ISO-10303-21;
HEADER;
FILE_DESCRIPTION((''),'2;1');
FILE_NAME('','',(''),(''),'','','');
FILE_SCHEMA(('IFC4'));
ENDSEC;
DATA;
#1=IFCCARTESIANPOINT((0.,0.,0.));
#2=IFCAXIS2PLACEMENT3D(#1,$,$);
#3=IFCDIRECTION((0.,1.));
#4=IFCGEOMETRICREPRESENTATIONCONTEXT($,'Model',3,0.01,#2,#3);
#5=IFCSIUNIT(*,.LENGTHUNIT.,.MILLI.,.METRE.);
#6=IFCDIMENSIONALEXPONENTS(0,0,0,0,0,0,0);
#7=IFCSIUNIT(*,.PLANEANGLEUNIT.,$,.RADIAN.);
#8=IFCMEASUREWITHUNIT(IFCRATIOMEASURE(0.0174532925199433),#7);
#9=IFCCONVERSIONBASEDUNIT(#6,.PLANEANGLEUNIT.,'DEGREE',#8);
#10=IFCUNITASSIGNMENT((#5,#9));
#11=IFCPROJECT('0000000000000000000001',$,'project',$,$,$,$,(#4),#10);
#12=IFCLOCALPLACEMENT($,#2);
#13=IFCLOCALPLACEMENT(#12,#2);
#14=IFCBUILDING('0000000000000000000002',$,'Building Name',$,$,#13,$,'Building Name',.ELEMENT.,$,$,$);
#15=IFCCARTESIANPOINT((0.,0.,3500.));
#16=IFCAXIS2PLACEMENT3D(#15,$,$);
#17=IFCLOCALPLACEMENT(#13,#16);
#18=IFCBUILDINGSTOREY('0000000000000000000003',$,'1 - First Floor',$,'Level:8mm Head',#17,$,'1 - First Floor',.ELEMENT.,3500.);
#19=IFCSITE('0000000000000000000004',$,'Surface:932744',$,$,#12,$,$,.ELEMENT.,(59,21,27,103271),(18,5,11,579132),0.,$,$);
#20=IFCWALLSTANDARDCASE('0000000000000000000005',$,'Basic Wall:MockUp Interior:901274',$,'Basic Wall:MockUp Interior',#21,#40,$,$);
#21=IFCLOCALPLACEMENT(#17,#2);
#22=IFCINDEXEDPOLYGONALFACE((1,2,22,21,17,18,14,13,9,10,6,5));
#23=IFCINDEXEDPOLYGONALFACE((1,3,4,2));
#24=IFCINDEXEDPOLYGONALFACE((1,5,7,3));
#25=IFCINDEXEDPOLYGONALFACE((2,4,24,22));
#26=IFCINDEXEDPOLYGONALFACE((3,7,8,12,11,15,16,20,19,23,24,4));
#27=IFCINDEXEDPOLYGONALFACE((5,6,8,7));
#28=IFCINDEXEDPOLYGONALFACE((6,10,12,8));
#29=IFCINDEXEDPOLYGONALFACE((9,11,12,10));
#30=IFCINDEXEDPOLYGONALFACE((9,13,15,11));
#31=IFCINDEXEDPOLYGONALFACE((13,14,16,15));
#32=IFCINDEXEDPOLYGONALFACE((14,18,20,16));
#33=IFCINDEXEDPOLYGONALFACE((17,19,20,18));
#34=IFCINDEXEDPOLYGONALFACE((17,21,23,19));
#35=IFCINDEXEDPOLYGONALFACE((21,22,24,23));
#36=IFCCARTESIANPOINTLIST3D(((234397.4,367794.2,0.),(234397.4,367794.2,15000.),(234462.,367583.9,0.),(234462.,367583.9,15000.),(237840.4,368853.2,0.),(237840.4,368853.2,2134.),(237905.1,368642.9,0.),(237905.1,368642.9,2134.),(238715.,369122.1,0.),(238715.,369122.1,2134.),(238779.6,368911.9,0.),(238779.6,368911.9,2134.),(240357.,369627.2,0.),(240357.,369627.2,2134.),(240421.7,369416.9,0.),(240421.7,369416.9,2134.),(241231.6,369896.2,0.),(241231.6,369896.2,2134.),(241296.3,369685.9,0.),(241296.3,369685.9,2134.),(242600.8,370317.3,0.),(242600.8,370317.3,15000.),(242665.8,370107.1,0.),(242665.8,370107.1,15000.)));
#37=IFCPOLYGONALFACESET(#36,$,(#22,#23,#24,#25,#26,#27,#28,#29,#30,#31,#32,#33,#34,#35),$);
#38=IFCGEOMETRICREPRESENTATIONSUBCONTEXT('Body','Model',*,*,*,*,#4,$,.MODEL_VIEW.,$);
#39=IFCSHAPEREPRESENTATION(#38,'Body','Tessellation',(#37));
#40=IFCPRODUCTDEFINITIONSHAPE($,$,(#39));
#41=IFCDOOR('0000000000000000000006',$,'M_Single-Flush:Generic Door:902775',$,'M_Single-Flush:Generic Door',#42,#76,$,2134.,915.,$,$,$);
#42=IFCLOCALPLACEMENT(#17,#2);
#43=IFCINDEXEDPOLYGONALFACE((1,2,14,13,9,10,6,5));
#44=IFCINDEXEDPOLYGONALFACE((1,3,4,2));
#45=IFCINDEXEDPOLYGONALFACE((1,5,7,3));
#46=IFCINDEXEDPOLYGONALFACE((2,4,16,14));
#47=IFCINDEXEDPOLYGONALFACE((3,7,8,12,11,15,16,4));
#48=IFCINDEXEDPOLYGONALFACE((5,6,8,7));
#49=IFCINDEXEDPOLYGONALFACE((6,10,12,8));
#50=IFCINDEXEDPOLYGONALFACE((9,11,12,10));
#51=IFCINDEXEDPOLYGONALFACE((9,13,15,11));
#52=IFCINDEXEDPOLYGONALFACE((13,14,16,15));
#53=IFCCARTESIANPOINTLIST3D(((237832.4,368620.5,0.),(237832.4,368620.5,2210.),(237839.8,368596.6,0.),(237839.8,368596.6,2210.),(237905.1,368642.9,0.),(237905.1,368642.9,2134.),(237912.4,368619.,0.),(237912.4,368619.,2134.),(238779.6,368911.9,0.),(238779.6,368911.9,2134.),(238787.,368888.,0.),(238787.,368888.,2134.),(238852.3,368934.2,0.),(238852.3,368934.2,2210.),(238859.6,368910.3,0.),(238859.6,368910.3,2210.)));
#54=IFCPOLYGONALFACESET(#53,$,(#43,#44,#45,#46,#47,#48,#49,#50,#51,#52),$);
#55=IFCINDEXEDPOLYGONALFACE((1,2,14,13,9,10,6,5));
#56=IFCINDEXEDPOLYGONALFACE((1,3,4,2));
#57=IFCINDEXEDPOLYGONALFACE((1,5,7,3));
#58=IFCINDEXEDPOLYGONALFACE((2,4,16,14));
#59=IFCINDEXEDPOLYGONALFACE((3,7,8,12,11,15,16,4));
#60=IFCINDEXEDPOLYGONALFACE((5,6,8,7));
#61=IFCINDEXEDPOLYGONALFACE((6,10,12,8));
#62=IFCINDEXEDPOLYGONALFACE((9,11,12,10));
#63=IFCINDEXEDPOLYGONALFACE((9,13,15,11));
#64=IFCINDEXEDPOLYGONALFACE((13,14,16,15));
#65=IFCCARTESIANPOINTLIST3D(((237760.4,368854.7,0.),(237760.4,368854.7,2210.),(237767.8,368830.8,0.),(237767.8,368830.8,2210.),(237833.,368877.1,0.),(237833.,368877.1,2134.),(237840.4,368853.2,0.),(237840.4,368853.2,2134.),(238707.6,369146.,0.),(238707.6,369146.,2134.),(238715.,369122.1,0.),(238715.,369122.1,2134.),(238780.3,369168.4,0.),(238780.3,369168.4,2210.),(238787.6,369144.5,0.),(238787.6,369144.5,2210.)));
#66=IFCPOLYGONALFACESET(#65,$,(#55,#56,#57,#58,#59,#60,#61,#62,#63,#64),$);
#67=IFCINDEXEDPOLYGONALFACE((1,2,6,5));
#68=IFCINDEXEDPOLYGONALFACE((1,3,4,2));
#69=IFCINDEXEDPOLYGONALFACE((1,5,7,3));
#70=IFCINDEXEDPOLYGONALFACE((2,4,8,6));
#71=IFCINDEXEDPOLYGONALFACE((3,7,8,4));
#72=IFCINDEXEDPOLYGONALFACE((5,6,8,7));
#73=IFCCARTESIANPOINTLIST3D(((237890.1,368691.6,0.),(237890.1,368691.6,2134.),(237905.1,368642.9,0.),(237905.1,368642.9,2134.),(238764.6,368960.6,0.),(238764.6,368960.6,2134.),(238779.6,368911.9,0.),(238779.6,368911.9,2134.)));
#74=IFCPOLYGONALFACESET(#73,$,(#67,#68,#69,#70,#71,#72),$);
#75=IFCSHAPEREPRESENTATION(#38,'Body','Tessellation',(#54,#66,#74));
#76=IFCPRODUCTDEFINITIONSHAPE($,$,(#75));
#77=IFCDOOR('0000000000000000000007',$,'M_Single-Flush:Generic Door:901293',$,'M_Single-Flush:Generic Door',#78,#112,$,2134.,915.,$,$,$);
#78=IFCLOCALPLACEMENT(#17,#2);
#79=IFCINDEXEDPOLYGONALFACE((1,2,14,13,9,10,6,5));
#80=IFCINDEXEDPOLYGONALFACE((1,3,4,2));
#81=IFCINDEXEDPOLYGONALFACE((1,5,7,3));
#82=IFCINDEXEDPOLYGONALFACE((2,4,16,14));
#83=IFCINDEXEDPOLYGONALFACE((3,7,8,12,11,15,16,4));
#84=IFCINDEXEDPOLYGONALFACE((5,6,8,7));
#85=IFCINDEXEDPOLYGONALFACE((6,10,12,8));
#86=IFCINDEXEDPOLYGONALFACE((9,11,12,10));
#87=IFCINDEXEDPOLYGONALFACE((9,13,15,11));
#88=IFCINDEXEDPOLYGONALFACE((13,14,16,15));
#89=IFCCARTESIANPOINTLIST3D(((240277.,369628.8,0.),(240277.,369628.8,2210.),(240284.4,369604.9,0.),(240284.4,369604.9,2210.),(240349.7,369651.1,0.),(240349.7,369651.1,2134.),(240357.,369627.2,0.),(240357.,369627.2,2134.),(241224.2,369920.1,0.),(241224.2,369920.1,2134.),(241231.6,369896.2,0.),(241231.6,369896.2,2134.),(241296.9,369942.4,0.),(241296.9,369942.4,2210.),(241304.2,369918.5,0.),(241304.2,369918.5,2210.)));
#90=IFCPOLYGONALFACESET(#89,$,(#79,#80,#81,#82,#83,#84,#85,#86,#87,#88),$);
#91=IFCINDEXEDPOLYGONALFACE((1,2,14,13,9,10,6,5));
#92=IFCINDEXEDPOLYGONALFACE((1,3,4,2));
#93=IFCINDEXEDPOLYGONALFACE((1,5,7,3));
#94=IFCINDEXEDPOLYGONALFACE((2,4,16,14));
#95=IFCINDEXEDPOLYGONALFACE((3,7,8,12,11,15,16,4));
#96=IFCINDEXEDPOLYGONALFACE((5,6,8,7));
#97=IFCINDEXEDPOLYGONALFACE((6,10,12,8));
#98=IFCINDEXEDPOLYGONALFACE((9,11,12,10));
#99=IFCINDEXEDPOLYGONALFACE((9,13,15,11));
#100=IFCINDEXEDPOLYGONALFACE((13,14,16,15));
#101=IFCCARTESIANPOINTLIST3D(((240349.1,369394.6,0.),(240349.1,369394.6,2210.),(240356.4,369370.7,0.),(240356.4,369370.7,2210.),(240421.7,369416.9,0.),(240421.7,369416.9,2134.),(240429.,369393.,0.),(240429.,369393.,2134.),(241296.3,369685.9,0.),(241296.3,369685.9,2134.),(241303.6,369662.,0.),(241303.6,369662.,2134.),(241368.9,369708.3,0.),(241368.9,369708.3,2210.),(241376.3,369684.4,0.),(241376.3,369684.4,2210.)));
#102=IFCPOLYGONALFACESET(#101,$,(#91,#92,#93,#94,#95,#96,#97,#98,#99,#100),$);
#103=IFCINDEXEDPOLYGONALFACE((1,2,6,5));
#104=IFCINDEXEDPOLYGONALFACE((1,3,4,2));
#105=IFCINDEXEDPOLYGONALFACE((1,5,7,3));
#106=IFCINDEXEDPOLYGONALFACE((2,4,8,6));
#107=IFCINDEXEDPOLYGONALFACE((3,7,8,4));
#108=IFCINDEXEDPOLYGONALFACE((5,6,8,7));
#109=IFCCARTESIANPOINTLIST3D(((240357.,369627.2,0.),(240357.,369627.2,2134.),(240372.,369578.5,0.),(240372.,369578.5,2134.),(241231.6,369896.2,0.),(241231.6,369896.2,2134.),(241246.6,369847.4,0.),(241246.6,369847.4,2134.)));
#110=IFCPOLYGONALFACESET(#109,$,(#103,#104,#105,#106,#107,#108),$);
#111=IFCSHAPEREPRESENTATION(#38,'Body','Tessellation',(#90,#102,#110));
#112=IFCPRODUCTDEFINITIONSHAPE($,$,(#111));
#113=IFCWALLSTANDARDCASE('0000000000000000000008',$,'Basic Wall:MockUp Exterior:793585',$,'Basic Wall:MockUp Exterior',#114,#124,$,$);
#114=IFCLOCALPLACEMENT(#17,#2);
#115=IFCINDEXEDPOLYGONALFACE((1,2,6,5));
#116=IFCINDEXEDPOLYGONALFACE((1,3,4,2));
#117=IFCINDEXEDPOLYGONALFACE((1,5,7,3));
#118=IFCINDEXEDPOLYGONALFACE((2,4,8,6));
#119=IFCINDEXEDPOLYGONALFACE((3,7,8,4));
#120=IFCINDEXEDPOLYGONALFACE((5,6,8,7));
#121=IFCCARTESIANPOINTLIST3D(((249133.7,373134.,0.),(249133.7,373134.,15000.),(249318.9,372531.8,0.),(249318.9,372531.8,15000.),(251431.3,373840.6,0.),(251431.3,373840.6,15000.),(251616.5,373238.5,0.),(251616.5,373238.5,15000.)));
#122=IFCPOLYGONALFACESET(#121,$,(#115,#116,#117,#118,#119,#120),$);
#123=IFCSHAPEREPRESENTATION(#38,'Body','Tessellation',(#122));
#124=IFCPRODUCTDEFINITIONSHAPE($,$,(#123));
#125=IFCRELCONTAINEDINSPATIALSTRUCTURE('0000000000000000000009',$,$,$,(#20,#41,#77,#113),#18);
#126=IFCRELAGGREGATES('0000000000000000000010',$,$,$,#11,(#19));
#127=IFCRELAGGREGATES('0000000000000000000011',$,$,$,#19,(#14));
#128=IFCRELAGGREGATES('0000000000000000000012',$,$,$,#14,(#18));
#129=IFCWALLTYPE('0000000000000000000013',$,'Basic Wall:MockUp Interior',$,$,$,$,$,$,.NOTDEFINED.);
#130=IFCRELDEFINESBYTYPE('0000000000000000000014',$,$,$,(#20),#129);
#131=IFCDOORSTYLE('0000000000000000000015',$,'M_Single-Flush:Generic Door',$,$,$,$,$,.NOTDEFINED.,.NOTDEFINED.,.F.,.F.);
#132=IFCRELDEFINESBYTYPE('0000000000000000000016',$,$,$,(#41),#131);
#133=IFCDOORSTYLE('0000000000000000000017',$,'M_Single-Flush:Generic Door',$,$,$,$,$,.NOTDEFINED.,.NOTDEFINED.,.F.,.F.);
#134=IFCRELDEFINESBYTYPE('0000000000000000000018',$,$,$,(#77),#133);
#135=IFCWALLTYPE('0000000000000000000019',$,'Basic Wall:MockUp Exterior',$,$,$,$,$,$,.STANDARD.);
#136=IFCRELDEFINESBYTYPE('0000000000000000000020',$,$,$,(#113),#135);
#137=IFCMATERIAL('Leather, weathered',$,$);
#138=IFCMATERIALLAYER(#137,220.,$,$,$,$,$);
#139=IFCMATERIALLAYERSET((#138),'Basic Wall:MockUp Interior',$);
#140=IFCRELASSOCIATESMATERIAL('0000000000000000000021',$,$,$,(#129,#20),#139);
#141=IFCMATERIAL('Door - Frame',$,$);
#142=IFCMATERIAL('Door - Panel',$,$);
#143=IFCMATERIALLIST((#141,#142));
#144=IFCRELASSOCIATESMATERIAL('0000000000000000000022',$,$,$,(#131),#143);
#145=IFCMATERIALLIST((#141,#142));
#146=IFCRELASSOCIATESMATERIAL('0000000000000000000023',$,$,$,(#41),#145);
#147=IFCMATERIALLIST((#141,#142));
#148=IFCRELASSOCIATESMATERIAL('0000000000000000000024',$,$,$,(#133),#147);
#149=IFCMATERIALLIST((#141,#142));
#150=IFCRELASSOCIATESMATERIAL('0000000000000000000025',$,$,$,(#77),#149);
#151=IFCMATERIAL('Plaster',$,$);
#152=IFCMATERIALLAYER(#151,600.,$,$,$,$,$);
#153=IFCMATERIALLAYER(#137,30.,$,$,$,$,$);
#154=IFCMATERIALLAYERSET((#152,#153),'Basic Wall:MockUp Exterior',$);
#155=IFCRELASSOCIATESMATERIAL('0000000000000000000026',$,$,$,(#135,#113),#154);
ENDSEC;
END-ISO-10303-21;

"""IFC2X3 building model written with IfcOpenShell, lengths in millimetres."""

from ifc_helpers import new_model, entity, si_unit, converted_unit, direction, frame, frame_2d, origin, place, context, subcontext, project, spatial, polyline, rectangle, outline, extrude, source, transform, mapped, material, material_list, layer, layer_set, layer_usage, type_object, type_shapes, element, fill, save


model = new_model("IFC2X3")

# Units and contexts
model_context = context("Model", 3, precision=0.01, world=origin(), true_north=direction((0.0, 1.0)))
body_context = subcontext(model_context, "Body", "Model", "MODEL_VIEW")
ifc_project = project(units=[si_unit("LENGTHUNIT", "METRE", prefix="MILLI"), converted_unit("PLANEANGLEUNIT", "DEGREE", entity("IfcRatioMeasure", 0.0174532925199433), si_unit("PLANEANGLEUNIT", "RADIAN"), dimensions=[0, 0, 0, 0, 0, 0, 0])], contexts=[model_context])

# Site, building, storey
site_placement = place(None, origin())
site = spatial("IfcSite", under=ifc_project, at=site_placement, Name="Surface:932744", CompositionType="ELEMENT", RefLatitude=(59, 21, 27, 103271), RefLongitude=(18, 5, 11, 579132), RefElevation=0.0)
building_placement = place(site_placement, origin())
building = spatial("IfcBuilding", under=site, at=building_placement, Name="Building Name", LongName="Building Name", CompositionType="ELEMENT")
storey_placement = place(building_placement, frame((0.0, 0.0, 3500.0)))
storey = spatial("IfcBuildingStorey", under=building, at=storey_placement, Name="1 - First Floor", ObjectType="Level:8mm Head", LongName="1 - First Floor", CompositionType="ELEMENT", Elevation=3500.0)

# Shared definitions
ifc_material_1 = material(Name="Leather, weathered")

# Shared definitions
ifc_material_2 = material(Name="Door - Frame")
ifc_material_3 = material(Name="Door - Panel")

# Shared definitions
ifc_layer_1 = layer(ifc_material_1, 220.0)
ifc_layer_set_1 = layer_set([ifc_layer_1], Name="Basic Wall:MockUp Interior")
wall_type_1 = type_object("IfcWallType", Name="Basic Wall:MockUp Interior", PredefinedType="NOTDEFINED", material=ifc_layer_set_1)
ifc_material_list_1 = material_list([ifc_material_2, ifc_material_3])
door_style_1 = type_object("IfcDoorStyle", Name="M_Single-Flush:Generic Door", ConstructionType="NOTDEFINED", OperationType="NOTDEFINED", ParameterTakesPrecedence=False, Sizeable=False, material=ifc_material_list_1)
shared_shape_1 = source(origin(), body_context, "Body", "SweptSolid", [
    extrude(outline(polyline([(-533.5, -1124.0), (533.5, -1124.0), (533.5, 1086.0), (457.5, 1086.0), (457.5, -1048.0), (-457.5, -1048.0), (-457.5, 1086.0), (-533.5, 1086.0), (-533.5, -1124.0)])), frame((457.5, 245.0, 1086.0), z_axis=(0.0, -1.0, 0.0), x_axis=(-1.0, 0.0, 0.0)), (0.0, 0.0, 1.0), 25.0),
    extrude(outline(polyline([(-1124.0, -533.5), (1086.0, -533.5), (1086.0, -457.5), (-1048.0, -457.5), (-1048.0, 457.5), (1086.0, 457.5), (1086.0, 533.5), (-1124.0, 533.5), (-1124.0, -533.5)])), frame((457.5, 0.0, 1086.0), z_axis=(0.0, -1.0, 0.0), x_axis=(0.0, 0.0, -1.0)), (0.0, 0.0, 1.0), 25.0),
    extrude(rectangle(XDim=915.0, YDim=51.0, at=frame_2d((0.0, 0.0), x_axis=(1.0, 0.0))), frame((457.5, 194.5, 0.0)), (0.0, 0.0, 1.0), 2134.0),
])
type_shapes(door_style_1, [shared_shape_1])

# Wall, openings, doors
ifc_layer_usage_1 = layer_usage(ifc_layer_set_1, "AXIS2", "NEGATIVE", 110.0)
wall_1_placement = place(storey_placement, frame((242633.4, 370212.3, 0.0), z_axis=(0.0, 0.0, 1.0), x_axis=(-0.955811, -0.29398, 0.0)))
wall_1 = element("IfcWallStandardCase", 1, at=wall_1_placement, inside=storey, type_object=wall_type_1, material=ifc_layer_usage_1, Name="Basic Wall:MockUp Interior:901274", ObjectType="Basic Wall:MockUp Interior", context=body_context, shape_type="SweptSolid", body=[
    extrude(outline(polyline([(0.3, -110.0), (8583.0, -110.0), (8583.0, 110.0), (3825.8, 110.0), (3605.8, 110.0), (220.0, 110.0), (0.0, 110.0), (0.3, -110.0)])), origin(), (0.0, 0.0, 1.0), 15000.0),
])
opening_1_placement = place(wall_1_placement, frame((2347.8, 110.0, 0.0)))
opening_1 = element("IfcOpeningElement", 2, at=opening_1_placement, cuts=wall_1, ObjectType="Opening", context=body_context, shape_type="SweptSolid", body=[
    extrude(rectangle(XDim=915.0, YDim=2134.0, at=frame_2d((1067.0, 457.5), x_axis=(0.0, 1.0))), frame((0.0, 0.0, 0.0), z_axis=(0.0, -1.0, 0.0), x_axis=(0.0, 0.0, 1.0)), (0.0, 0.0, 1.0), 220.0),
])
opening_2_placement = place(wall_1_placement, frame((4065.8, -110.0, 0.0)))
opening_2 = element("IfcOpeningElement", 3, at=opening_2_placement, cuts=wall_1, ObjectType="Opening", context=body_context, shape_type="SweptSolid", body=[
    extrude(rectangle(XDim=915.0, YDim=2134.0, at=frame_2d((1067.0, 457.5), x_axis=(0.0, -1.0))), frame((0.0, 0.0, 0.0), z_axis=(0.0, 1.0, 0.0), x_axis=(0.0, 0.0, 1.0)), (0.0, 0.0, 1.0), 220.0),
])
ifc_material_list_2 = material_list([ifc_material_2, ifc_material_3])
door_1_placement = place(opening_2_placement, origin())
door_1 = element("IfcDoor", 4, at=door_1_placement, inside=storey, type_object=door_style_1, material=ifc_material_list_2, Name="M_Single-Flush:Generic Door:902775", ObjectType="M_Single-Flush:Generic Door", OverallHeight=2134.0, OverallWidth=915.0, context=body_context, shape_type="MappedRepresentation", body=[
    mapped(shared_shape_1, transform((0.0, 0.0, 0.0), scale=1.0)),
])
fill(opening_2, door_1)
ifc_material_list_3 = material_list([ifc_material_2, ifc_material_3])
ifc_material_list_4 = material_list([ifc_material_2, ifc_material_3])
door_style_2 = type_object("IfcDoorStyle", Name="M_Single-Flush:Generic Door", ConstructionType="NOTDEFINED", OperationType="NOTDEFINED", ParameterTakesPrecedence=False, Sizeable=False, material=ifc_material_list_4)
shared_shape_2 = source(origin(), body_context, "Body", "SweptSolid", [
    extrude(outline(polyline([(-533.5, -1124.0), (533.5, -1124.0), (533.5, 1086.0), (457.5, 1086.0), (457.5, -1048.0), (-457.5, -1048.0), (-457.5, 1086.0), (-533.5, 1086.0), (-533.5, -1124.0)])), frame((457.5, 220.0, 1086.0), z_axis=(0.0, 1.0, 0.0), x_axis=(1.0, 0.0, 0.0)), (0.0, 0.0, 1.0), 25.0),
    extrude(outline(polyline([(-1124.0, -533.5), (1086.0, -533.5), (1086.0, -457.5), (-1048.0, -457.5), (-1048.0, 457.5), (1086.0, 457.5), (1086.0, 533.5), (-1124.0, 533.5), (-1124.0, -533.5)])), frame((457.5, -25.0, 1086.0), z_axis=(0.0, 1.0, 0.0), x_axis=(0.0, 0.0, -1.0)), (0.0, 0.0, 1.0), 25.0),
    extrude(rectangle(XDim=51.0, YDim=915.0, at=frame_2d((0.0, 0.0), x_axis=(1.0, 0.0))), frame((457.5, 194.5, 0.0), z_axis=(0.0, 0.0, 1.0), x_axis=(0.0, 1.0, 0.0)), (0.0, 0.0, 1.0), 2134.0),
])
type_shapes(door_style_2, [shared_shape_2])
door_2_placement = place(opening_1_placement, frame((0.0, 0.0, 0.0), z_axis=(0.0, 0.0, 1.0), x_axis=(-1.0, 0.0, 0.0)))
door_2 = element("IfcDoor", 5, at=door_2_placement, inside=storey, type_object=door_style_2, material=ifc_material_list_3, Name="M_Single-Flush:Generic Door:901293", ObjectType="M_Single-Flush:Generic Door", OverallHeight=2134.0, OverallWidth=915.0, context=body_context, shape_type="MappedRepresentation", body=[
    mapped(shared_shape_2, transform((0.0, 0.0, 0.0), scale=1.0)),
])
fill(opening_1, door_2)

# Wall
ifc_material_4 = material(Name="Plaster")
ifc_layer_2 = layer(ifc_material_4, 600.0)
ifc_layer_3 = layer(ifc_material_1, 30.0)
ifc_layer_set_2 = layer_set([ifc_layer_2, ifc_layer_3], Name="Basic Wall:MockUp Exterior")
ifc_layer_usage_2 = layer_usage(ifc_layer_set_2, "AXIS2", "NEGATIVE", 315.0)
wall_type_2 = type_object("IfcWallType", Name="Basic Wall:MockUp Exterior", PredefinedType="STANDARD", material=ifc_layer_set_2)
wall_2_placement = place(storey_placement, frame((249226.3, 372832.9, 0.0), z_axis=(0.0, 0.0, 1.0), x_axis=(0.955811, 0.29398, 0.0)))
element("IfcWallStandardCase", 6, at=wall_2_placement, inside=storey, type_object=wall_type_2, material=ifc_layer_usage_2, Name="Basic Wall:MockUp Exterior:793585", ObjectType="Basic Wall:MockUp Exterior", context=body_context, shape_type="SweptSolid", body=[
    extrude(rectangle(XDim=2403.8, YDim=630.0, at=frame_2d((1201.9, 0.0), x_axis=(-1.0, 0.0))), origin(), (0.0, 0.0, 1.0), 15000.0),
])

save(model, "model.ifc")
